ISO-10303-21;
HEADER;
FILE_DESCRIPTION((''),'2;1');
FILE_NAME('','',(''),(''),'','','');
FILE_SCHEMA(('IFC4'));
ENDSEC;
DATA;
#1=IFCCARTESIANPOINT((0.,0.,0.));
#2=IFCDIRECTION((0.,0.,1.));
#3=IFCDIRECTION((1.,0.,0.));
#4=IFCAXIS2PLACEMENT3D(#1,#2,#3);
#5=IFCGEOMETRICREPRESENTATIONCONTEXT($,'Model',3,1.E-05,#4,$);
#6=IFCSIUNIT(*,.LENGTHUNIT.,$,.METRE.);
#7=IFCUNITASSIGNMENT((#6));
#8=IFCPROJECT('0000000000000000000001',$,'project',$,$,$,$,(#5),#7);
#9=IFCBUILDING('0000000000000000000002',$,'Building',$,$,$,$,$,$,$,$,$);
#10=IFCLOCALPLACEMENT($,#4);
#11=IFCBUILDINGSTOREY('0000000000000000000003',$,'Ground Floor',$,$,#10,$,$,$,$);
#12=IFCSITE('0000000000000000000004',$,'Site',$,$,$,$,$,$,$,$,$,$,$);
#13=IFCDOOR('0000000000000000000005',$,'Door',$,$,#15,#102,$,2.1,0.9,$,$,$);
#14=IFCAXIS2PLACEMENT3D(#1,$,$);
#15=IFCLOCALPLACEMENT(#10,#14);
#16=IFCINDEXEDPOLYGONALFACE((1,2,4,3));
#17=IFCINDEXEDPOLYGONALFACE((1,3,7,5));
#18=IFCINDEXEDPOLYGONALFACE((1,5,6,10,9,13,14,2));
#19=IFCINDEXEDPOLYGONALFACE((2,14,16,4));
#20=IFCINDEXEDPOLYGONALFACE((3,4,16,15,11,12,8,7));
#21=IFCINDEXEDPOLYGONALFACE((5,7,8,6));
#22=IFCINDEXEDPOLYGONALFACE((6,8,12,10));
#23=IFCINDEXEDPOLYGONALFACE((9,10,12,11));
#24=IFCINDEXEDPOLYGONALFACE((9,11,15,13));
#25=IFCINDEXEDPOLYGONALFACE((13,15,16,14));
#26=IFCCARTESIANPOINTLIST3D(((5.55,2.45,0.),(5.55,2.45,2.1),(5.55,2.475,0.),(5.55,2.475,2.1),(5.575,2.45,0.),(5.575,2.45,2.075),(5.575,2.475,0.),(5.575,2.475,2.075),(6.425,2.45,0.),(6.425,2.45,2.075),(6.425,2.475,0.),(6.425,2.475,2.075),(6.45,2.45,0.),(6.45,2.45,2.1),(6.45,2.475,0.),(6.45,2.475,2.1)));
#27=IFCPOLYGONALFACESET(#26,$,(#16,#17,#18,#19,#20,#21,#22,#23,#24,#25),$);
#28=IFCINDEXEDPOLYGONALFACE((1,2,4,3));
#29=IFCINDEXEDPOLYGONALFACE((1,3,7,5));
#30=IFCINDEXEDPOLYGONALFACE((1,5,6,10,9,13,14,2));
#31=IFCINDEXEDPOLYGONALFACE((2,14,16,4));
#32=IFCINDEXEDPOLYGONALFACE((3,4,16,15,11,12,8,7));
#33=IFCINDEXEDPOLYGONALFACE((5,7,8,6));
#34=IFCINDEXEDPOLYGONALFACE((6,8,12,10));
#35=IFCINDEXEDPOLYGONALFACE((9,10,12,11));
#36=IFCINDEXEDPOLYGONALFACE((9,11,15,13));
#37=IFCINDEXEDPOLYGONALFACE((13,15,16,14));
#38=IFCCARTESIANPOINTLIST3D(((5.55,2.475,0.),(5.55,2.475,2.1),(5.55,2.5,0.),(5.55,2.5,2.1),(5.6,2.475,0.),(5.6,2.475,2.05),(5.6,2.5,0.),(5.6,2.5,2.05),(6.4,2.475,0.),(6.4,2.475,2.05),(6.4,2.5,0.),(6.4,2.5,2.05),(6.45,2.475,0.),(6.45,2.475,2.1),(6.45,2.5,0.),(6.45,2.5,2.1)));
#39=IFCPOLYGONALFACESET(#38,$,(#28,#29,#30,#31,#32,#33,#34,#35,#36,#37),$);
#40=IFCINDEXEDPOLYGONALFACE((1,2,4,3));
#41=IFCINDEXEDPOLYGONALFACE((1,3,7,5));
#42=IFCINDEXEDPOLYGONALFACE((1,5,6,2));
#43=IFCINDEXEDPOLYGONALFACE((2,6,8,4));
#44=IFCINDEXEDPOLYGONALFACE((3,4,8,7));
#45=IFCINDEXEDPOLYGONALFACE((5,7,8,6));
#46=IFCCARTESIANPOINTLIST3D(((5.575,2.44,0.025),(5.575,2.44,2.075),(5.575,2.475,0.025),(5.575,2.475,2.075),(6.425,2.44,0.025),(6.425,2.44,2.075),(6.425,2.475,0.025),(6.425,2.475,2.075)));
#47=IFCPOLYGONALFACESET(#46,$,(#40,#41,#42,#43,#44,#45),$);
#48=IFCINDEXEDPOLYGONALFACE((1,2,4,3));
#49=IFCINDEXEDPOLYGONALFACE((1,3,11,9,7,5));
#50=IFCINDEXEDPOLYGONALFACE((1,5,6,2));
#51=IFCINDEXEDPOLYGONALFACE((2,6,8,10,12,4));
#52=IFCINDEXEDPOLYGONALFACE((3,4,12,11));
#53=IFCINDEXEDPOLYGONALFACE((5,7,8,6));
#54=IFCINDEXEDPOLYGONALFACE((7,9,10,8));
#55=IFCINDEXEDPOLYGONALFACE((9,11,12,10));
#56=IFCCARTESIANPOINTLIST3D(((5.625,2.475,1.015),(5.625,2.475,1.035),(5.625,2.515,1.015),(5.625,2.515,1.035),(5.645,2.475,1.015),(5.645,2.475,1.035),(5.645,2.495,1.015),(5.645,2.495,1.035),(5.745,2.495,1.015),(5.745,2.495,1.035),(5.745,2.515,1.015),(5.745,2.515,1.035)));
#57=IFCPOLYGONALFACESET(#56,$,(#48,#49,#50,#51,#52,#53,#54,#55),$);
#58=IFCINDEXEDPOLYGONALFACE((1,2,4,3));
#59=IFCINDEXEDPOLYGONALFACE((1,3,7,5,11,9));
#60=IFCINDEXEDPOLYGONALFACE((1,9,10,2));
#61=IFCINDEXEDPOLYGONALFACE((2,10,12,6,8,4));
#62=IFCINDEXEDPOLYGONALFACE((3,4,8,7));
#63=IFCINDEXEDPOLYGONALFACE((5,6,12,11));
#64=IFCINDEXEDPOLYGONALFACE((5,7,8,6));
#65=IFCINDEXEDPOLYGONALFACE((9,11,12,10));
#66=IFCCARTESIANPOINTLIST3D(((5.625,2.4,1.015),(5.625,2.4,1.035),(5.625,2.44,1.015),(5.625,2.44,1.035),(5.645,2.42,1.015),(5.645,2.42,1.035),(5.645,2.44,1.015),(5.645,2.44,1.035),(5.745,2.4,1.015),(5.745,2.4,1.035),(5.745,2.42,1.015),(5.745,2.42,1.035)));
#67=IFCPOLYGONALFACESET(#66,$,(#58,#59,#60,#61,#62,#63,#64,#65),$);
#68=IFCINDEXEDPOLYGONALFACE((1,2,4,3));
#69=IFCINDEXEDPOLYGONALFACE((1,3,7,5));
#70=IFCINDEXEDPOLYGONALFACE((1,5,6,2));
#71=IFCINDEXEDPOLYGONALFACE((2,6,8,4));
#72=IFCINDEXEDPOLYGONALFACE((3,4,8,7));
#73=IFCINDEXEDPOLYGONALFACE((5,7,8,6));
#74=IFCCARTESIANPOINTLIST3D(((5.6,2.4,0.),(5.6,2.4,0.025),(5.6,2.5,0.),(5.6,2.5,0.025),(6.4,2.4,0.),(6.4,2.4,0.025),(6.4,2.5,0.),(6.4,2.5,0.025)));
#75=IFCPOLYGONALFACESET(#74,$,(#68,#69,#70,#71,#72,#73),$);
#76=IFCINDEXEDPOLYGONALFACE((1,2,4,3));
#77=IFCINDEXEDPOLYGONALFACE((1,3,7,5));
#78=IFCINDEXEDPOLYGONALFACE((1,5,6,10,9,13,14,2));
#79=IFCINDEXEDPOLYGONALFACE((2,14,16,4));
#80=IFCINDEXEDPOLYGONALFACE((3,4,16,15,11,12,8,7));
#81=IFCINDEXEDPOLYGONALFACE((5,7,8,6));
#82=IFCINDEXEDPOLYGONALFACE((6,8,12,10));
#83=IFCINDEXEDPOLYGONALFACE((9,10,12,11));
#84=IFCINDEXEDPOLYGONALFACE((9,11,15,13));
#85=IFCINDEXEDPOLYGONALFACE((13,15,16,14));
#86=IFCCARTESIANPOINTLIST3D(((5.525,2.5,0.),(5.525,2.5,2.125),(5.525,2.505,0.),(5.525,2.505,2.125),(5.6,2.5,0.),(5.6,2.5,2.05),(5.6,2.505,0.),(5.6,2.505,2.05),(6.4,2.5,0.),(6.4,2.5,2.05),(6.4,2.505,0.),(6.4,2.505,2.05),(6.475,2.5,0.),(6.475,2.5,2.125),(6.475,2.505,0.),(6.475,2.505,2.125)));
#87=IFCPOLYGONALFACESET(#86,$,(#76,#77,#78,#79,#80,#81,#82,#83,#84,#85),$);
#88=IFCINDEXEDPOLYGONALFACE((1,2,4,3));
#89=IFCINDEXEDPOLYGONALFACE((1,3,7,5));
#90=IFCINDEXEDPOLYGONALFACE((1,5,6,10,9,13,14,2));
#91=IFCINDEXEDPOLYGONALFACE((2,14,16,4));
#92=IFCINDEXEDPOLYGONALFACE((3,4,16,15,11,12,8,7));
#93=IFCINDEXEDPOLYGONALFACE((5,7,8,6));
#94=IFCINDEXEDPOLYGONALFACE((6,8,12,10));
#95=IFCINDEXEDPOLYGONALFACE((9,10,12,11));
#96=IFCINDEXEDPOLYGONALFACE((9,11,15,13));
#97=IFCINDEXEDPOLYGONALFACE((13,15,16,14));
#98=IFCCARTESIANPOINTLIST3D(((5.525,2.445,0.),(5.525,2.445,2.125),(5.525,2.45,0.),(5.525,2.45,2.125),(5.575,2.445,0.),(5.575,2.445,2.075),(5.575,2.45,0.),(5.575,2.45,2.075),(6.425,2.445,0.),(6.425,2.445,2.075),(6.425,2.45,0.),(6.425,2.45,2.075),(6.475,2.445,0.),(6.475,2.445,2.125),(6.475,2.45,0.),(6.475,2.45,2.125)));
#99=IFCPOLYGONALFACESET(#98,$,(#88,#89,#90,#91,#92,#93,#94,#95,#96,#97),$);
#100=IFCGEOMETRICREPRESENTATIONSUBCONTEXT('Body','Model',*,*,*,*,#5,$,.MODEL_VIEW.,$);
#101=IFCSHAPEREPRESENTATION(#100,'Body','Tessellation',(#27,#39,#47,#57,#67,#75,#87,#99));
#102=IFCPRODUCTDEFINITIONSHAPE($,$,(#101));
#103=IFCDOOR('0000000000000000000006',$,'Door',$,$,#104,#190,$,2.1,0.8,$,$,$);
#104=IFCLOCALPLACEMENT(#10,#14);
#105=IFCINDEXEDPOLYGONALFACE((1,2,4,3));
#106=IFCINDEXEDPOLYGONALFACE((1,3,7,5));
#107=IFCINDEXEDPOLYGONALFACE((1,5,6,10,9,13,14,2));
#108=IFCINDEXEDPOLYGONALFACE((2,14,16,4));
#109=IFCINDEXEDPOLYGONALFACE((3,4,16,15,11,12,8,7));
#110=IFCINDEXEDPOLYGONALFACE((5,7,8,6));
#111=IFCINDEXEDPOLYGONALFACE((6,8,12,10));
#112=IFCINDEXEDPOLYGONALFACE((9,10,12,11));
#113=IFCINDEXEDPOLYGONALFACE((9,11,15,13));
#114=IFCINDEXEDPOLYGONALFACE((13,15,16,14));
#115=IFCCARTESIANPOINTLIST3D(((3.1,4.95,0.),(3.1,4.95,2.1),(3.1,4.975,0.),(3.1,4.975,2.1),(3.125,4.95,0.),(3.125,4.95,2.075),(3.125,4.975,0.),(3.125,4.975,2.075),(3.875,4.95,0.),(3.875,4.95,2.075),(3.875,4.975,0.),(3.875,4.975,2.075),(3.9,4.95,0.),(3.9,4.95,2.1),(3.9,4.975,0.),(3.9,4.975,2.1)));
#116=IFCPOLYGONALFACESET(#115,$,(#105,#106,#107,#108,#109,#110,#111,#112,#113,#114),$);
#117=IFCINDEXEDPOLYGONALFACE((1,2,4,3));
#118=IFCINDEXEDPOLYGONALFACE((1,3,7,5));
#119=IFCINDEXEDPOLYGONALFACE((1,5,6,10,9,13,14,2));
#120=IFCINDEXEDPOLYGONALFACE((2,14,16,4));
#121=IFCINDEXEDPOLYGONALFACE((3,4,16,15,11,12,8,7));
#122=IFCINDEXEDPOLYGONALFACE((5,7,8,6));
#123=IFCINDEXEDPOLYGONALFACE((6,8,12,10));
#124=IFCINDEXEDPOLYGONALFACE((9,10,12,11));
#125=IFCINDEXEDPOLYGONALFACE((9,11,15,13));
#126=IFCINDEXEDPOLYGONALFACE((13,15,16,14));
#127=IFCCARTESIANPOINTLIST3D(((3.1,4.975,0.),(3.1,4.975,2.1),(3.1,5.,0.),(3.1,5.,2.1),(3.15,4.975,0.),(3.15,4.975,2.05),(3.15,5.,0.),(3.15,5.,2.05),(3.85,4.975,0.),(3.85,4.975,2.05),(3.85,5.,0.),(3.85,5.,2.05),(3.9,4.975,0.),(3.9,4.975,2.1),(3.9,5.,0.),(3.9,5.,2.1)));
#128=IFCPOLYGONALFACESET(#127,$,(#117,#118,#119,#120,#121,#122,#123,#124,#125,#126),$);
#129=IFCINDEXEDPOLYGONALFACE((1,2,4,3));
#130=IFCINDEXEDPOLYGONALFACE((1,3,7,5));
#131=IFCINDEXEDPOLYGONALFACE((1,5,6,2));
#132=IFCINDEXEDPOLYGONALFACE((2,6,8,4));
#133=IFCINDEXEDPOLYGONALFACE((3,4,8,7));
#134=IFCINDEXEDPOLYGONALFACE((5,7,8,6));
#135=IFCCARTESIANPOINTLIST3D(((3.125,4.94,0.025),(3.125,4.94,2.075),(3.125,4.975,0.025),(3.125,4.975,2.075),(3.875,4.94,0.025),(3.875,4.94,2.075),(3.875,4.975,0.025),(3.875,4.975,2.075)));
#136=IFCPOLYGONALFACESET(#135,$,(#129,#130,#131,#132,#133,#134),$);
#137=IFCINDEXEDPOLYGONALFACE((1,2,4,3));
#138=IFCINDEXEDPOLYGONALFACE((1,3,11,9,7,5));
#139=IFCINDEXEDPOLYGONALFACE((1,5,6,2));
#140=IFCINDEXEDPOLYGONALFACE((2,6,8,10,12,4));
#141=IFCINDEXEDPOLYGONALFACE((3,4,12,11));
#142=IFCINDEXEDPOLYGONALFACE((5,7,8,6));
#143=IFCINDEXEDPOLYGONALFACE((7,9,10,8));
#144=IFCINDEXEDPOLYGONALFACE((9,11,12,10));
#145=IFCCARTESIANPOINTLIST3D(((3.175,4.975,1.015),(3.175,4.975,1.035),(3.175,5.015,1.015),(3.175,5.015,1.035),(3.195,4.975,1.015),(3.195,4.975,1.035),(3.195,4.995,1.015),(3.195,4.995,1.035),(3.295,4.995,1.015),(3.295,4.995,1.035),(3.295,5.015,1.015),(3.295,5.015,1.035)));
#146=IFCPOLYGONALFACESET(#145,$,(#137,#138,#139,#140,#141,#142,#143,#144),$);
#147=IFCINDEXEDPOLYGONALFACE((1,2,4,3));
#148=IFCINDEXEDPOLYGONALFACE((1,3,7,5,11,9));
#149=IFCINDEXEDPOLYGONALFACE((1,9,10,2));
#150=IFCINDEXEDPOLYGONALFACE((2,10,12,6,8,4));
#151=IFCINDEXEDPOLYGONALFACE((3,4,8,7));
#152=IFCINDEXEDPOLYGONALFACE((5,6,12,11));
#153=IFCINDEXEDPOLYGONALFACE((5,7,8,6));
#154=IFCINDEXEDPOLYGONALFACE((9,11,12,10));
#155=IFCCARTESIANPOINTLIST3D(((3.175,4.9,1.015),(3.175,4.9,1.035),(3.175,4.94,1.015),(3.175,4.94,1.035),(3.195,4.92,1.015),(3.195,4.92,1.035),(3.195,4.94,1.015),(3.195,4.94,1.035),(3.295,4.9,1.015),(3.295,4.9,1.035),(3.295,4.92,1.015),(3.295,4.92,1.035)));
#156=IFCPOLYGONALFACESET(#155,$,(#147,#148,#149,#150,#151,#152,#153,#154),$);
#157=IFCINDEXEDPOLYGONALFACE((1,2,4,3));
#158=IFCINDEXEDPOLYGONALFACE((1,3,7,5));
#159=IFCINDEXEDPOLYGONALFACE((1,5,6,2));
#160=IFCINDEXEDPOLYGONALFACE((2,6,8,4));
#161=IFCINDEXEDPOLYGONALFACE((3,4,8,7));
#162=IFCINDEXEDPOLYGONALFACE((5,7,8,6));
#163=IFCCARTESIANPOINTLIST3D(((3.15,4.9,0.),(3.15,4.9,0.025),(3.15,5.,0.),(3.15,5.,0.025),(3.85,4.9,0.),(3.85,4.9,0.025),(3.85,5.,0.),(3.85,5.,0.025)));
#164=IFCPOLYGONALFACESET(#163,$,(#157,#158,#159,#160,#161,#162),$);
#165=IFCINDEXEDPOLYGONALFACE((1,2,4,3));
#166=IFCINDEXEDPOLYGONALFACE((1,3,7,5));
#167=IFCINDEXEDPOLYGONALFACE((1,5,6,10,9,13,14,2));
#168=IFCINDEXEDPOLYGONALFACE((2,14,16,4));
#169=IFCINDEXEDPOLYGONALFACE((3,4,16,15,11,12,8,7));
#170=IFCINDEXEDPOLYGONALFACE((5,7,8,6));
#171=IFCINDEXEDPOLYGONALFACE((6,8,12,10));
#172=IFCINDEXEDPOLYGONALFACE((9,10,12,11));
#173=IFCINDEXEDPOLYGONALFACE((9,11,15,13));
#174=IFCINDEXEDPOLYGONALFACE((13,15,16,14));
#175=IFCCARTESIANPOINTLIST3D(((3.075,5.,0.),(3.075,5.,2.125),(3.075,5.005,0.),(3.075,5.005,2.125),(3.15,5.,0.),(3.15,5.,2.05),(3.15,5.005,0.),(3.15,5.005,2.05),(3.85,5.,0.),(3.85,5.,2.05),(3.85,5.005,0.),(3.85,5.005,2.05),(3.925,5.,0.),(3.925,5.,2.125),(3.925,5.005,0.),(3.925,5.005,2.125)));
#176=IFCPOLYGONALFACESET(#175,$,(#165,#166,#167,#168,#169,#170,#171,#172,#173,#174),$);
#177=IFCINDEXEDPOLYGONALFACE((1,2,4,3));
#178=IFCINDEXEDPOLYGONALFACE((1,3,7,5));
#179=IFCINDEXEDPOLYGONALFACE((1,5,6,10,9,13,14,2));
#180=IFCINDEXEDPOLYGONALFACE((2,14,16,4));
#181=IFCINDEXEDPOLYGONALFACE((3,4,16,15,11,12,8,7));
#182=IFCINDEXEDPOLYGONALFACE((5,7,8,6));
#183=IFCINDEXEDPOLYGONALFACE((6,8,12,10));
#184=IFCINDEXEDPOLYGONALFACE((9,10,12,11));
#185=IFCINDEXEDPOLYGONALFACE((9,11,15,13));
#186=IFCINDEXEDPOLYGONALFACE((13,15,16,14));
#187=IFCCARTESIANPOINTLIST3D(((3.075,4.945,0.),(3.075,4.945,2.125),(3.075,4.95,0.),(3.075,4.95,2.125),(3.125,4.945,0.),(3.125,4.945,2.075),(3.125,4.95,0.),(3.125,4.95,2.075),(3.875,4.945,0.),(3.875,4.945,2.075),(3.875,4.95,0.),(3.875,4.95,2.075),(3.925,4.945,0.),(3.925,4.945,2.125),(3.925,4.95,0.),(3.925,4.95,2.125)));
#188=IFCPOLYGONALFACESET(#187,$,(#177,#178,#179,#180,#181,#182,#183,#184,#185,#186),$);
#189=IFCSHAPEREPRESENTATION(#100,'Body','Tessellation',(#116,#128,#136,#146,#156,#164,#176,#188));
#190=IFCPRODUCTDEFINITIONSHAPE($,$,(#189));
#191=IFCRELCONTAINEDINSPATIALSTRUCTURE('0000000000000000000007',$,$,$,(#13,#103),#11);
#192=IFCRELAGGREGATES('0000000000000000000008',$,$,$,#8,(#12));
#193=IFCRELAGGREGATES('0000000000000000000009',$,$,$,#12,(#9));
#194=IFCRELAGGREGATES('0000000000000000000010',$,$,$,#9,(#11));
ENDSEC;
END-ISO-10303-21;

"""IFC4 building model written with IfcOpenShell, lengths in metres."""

from ifc_helpers import new_model, si_unit, frame, origin_with_axes, place, context, subcontext, project, spatial, line, indexed_curve, outline, extrude, element, save


model = new_model("IFC4")

# Units and contexts
model_context = context("Model", 3, precision=1e-05, world=origin_with_axes())
body_context = subcontext(model_context, "Body", "Model", "MODEL_VIEW")
ifc_project = project(units=[si_unit("LENGTHUNIT", "METRE")], contexts=[model_context])

# Site, building, storey
site = spatial("IfcSite", under=ifc_project, Name="Site")
building = spatial("IfcBuilding", under=site, Name="Building")
storey_placement = place(None, origin_with_axes())
storey = spatial("IfcBuildingStorey", under=building, at=storey_placement, Name="Ground Floor")

# Doors
door_1_placement = place(storey_placement, frame((6.45, 2.5, 0.0), z_axis=(0.0, 0.0, 1.0), x_axis=(-1.0, 0.0, 0.0)))
element("IfcDoor", 1, at=door_1_placement, inside=storey, Name="Door", OverallHeight=2.1, OverallWidth=0.9, context=body_context, shape_type="SweptSolid", body=[
    extrude(outline(indexed_curve([(0.0, 0.0), (0.0, 2.1), (0.9, 2.1), (0.9, 0.0), (0.875, 0.0), (0.875, 2.075), (0.025, 2.075), (0.025, 0.0)], segments=[line(1, 2, 3, 4, 5, 6, 7, 8, 1)])), frame((0.0, 0.025, 0.0), z_axis=(0.0, -1.0, 0.0), x_axis=(1.0, 0.0, 0.0)), (0.0, 0.0, -1.0), 0.025),
    extrude(outline(indexed_curve([(0.0, 0.0), (0.0, 2.1), (0.9, 2.1), (0.9, 0.0), (0.85, 0.0), (0.85, 2.05), (0.05, 2.05), (0.05, 0.0)], segments=[line(1, 2, 3, 4, 5, 6, 7, 8, 1)])), frame((0.0, 0.0, 0.0), z_axis=(0.0, -1.0, 0.0), x_axis=(1.0, 0.0, 0.0)), (0.0, 0.0, -1.0), 0.025),
    extrude(outline(indexed_curve([(0.0, 0.0), (0.85, 0.0), (0.85, 0.035), (0.0, 0.035)], segments=[line(1, 2, 3, 4, 1)])), frame((0.025, 0.025, 0.025), z_axis=(0.0, 0.0, 1.0), x_axis=(1.0, 0.0, 0.0)), (0.0, 0.0, 1.0), 2.05),
    extrude(outline(indexed_curve([(0.0, 0.0), (0.0, -0.04), (-0.12, -0.04), (-0.12, -0.02), (-0.02, -0.02), (-0.02, 0.0)], segments=[line(1, 2, 3, 4, 5, 6, 1)])), frame((0.825, 0.025, 1.015), z_axis=(0.0, 0.0, 1.0), x_axis=(1.0, 0.0, 0.0)), (0.0, 0.0, 1.0), 0.02),
    extrude(outline(indexed_curve([(0.0, 0.0), (0.0, 0.04), (-0.12, 0.04), (-0.12, 0.02), (-0.02, 0.02), (-0.02, 0.0)], segments=[line(1, 2, 3, 4, 5, 6, 1)])), frame((0.825, 0.06, 1.015), z_axis=(0.0, 0.0, 1.0), x_axis=(1.0, 0.0, 0.0)), (0.0, 0.0, 1.0), 0.02),
    extrude(outline(indexed_curve([(0.0, 0.0), (0.8, 0.0), (0.8, 0.1), (0.0, 0.1)], segments=[line(1, 2, 3, 4, 1)])), frame((0.05, 0.0, 0.0), z_axis=(0.0, 0.0, 1.0), x_axis=(1.0, 0.0, 0.0)), (0.0, 0.0, 1.0), 0.025),
    extrude(outline(indexed_curve([(0.0, 0.0), (0.0, 2.125), (0.95, 2.125), (0.95, 0.0), (0.875, 0.0), (0.875, 2.05), (0.075, 2.05), (0.075, 0.0)], segments=[line(1, 2, 3, 4, 5, 6, 7, 8, 1)])), frame((-0.025, -0.005, 0.0), z_axis=(0.0, -1.0, 0.0), x_axis=(1.0, 0.0, 0.0)), (0.0, 0.0, -1.0), 0.005),
    extrude(outline(indexed_curve([(0.0, 0.0), (0.0, 2.125), (0.95, 2.125), (0.95, 0.0), (0.9, 0.0), (0.9, 2.075), (0.05, 2.075), (0.05, 0.0)], segments=[line(1, 2, 3, 4, 5, 6, 7, 8, 1)])), frame((-0.025, 0.05, 0.0), z_axis=(0.0, -1.0, 0.0), x_axis=(1.0, 0.0, 0.0)), (0.0, 0.0, -1.0), 0.005),
])
door_2_placement = place(storey_placement, frame((3.9, 5.0, 0.0), z_axis=(0.0, 0.0, 1.0), x_axis=(-1.0, 0.0, 0.0)))
element("IfcDoor", 2, at=door_2_placement, inside=storey, Name="Door", OverallHeight=2.1, OverallWidth=0.8, context=body_context, shape_type="SweptSolid", body=[
    extrude(outline(indexed_curve([(0.0, 0.0), (0.0, 2.1), (0.8, 2.1), (0.8, 0.0), (0.775, 0.0), (0.775, 2.075), (0.025, 2.075), (0.025, 0.0)], segments=[line(1, 2, 3, 4, 5, 6, 7, 8, 1)])), frame((0.0, 0.025, 0.0), z_axis=(0.0, -1.0, 0.0), x_axis=(1.0, 0.0, 0.0)), (0.0, 0.0, -1.0), 0.025),
    extrude(outline(indexed_curve([(0.0, 0.0), (0.0, 2.1), (0.8, 2.1), (0.8, 0.0), (0.75, 0.0), (0.75, 2.05), (0.05, 2.05), (0.05, 0.0)], segments=[line(1, 2, 3, 4, 5, 6, 7, 8, 1)])), frame((0.0, 0.0, 0.0), z_axis=(0.0, -1.0, 0.0), x_axis=(1.0, 0.0, 0.0)), (0.0, 0.0, -1.0), 0.025),
    extrude(outline(indexed_curve([(0.0, 0.0), (0.75, 0.0), (0.75, 0.035), (0.0, 0.035)], segments=[line(1, 2, 3, 4, 1)])), frame((0.025, 0.025, 0.025), z_axis=(0.0, 0.0, 1.0), x_axis=(1.0, 0.0, 0.0)), (0.0, 0.0, 1.0), 2.05),
    extrude(outline(indexed_curve([(0.0, 0.0), (0.0, -0.04), (-0.12, -0.04), (-0.12, -0.02), (-0.02, -0.02), (-0.02, 0.0)], segments=[line(1, 2, 3, 4, 5, 6, 1)])), frame((0.725, 0.025, 1.015), z_axis=(0.0, 0.0, 1.0), x_axis=(1.0, 0.0, 0.0)), (0.0, 0.0, 1.0), 0.02),
    extrude(outline(indexed_curve([(0.0, 0.0), (0.0, 0.04), (-0.12, 0.04), (-0.12, 0.02), (-0.02, 0.02), (-0.02, 0.0)], segments=[line(1, 2, 3, 4, 5, 6, 1)])), frame((0.725, 0.06, 1.015), z_axis=(0.0, 0.0, 1.0), x_axis=(1.0, 0.0, 0.0)), (0.0, 0.0, 1.0), 0.02),
    extrude(outline(indexed_curve([(0.0, 0.0), (0.7, 0.0), (0.7, 0.1), (0.0, 0.1)], segments=[line(1, 2, 3, 4, 1)])), frame((0.05, 0.0, 0.0), z_axis=(0.0, 0.0, 1.0), x_axis=(1.0, 0.0, 0.0)), (0.0, 0.0, 1.0), 0.025),
    extrude(outline(indexed_curve([(0.0, 0.0), (0.0, 2.125), (0.85, 2.125), (0.85, 0.0), (0.775, 0.0), (0.775, 2.05), (0.075, 2.05), (0.075, 0.0)], segments=[line(1, 2, 3, 4, 5, 6, 7, 8, 1)])), frame((-0.025, -0.005, 0.0), z_axis=(0.0, -1.0, 0.0), x_axis=(1.0, 0.0, 0.0)), (0.0, 0.0, -1.0), 0.005),
    extrude(outline(indexed_curve([(0.0, 0.0), (0.0, 2.125), (0.85, 2.125), (0.85, 0.0), (0.8, 0.0), (0.8, 2.075), (0.05, 2.075), (0.05, 0.0)], segments=[line(1, 2, 3, 4, 5, 6, 7, 8, 1)])), frame((-0.025, 0.05, 0.0), z_axis=(0.0, -1.0, 0.0), x_axis=(1.0, 0.0, 0.0)), (0.0, 0.0, -1.0), 0.005),
])

save(model, "model.ifc")
